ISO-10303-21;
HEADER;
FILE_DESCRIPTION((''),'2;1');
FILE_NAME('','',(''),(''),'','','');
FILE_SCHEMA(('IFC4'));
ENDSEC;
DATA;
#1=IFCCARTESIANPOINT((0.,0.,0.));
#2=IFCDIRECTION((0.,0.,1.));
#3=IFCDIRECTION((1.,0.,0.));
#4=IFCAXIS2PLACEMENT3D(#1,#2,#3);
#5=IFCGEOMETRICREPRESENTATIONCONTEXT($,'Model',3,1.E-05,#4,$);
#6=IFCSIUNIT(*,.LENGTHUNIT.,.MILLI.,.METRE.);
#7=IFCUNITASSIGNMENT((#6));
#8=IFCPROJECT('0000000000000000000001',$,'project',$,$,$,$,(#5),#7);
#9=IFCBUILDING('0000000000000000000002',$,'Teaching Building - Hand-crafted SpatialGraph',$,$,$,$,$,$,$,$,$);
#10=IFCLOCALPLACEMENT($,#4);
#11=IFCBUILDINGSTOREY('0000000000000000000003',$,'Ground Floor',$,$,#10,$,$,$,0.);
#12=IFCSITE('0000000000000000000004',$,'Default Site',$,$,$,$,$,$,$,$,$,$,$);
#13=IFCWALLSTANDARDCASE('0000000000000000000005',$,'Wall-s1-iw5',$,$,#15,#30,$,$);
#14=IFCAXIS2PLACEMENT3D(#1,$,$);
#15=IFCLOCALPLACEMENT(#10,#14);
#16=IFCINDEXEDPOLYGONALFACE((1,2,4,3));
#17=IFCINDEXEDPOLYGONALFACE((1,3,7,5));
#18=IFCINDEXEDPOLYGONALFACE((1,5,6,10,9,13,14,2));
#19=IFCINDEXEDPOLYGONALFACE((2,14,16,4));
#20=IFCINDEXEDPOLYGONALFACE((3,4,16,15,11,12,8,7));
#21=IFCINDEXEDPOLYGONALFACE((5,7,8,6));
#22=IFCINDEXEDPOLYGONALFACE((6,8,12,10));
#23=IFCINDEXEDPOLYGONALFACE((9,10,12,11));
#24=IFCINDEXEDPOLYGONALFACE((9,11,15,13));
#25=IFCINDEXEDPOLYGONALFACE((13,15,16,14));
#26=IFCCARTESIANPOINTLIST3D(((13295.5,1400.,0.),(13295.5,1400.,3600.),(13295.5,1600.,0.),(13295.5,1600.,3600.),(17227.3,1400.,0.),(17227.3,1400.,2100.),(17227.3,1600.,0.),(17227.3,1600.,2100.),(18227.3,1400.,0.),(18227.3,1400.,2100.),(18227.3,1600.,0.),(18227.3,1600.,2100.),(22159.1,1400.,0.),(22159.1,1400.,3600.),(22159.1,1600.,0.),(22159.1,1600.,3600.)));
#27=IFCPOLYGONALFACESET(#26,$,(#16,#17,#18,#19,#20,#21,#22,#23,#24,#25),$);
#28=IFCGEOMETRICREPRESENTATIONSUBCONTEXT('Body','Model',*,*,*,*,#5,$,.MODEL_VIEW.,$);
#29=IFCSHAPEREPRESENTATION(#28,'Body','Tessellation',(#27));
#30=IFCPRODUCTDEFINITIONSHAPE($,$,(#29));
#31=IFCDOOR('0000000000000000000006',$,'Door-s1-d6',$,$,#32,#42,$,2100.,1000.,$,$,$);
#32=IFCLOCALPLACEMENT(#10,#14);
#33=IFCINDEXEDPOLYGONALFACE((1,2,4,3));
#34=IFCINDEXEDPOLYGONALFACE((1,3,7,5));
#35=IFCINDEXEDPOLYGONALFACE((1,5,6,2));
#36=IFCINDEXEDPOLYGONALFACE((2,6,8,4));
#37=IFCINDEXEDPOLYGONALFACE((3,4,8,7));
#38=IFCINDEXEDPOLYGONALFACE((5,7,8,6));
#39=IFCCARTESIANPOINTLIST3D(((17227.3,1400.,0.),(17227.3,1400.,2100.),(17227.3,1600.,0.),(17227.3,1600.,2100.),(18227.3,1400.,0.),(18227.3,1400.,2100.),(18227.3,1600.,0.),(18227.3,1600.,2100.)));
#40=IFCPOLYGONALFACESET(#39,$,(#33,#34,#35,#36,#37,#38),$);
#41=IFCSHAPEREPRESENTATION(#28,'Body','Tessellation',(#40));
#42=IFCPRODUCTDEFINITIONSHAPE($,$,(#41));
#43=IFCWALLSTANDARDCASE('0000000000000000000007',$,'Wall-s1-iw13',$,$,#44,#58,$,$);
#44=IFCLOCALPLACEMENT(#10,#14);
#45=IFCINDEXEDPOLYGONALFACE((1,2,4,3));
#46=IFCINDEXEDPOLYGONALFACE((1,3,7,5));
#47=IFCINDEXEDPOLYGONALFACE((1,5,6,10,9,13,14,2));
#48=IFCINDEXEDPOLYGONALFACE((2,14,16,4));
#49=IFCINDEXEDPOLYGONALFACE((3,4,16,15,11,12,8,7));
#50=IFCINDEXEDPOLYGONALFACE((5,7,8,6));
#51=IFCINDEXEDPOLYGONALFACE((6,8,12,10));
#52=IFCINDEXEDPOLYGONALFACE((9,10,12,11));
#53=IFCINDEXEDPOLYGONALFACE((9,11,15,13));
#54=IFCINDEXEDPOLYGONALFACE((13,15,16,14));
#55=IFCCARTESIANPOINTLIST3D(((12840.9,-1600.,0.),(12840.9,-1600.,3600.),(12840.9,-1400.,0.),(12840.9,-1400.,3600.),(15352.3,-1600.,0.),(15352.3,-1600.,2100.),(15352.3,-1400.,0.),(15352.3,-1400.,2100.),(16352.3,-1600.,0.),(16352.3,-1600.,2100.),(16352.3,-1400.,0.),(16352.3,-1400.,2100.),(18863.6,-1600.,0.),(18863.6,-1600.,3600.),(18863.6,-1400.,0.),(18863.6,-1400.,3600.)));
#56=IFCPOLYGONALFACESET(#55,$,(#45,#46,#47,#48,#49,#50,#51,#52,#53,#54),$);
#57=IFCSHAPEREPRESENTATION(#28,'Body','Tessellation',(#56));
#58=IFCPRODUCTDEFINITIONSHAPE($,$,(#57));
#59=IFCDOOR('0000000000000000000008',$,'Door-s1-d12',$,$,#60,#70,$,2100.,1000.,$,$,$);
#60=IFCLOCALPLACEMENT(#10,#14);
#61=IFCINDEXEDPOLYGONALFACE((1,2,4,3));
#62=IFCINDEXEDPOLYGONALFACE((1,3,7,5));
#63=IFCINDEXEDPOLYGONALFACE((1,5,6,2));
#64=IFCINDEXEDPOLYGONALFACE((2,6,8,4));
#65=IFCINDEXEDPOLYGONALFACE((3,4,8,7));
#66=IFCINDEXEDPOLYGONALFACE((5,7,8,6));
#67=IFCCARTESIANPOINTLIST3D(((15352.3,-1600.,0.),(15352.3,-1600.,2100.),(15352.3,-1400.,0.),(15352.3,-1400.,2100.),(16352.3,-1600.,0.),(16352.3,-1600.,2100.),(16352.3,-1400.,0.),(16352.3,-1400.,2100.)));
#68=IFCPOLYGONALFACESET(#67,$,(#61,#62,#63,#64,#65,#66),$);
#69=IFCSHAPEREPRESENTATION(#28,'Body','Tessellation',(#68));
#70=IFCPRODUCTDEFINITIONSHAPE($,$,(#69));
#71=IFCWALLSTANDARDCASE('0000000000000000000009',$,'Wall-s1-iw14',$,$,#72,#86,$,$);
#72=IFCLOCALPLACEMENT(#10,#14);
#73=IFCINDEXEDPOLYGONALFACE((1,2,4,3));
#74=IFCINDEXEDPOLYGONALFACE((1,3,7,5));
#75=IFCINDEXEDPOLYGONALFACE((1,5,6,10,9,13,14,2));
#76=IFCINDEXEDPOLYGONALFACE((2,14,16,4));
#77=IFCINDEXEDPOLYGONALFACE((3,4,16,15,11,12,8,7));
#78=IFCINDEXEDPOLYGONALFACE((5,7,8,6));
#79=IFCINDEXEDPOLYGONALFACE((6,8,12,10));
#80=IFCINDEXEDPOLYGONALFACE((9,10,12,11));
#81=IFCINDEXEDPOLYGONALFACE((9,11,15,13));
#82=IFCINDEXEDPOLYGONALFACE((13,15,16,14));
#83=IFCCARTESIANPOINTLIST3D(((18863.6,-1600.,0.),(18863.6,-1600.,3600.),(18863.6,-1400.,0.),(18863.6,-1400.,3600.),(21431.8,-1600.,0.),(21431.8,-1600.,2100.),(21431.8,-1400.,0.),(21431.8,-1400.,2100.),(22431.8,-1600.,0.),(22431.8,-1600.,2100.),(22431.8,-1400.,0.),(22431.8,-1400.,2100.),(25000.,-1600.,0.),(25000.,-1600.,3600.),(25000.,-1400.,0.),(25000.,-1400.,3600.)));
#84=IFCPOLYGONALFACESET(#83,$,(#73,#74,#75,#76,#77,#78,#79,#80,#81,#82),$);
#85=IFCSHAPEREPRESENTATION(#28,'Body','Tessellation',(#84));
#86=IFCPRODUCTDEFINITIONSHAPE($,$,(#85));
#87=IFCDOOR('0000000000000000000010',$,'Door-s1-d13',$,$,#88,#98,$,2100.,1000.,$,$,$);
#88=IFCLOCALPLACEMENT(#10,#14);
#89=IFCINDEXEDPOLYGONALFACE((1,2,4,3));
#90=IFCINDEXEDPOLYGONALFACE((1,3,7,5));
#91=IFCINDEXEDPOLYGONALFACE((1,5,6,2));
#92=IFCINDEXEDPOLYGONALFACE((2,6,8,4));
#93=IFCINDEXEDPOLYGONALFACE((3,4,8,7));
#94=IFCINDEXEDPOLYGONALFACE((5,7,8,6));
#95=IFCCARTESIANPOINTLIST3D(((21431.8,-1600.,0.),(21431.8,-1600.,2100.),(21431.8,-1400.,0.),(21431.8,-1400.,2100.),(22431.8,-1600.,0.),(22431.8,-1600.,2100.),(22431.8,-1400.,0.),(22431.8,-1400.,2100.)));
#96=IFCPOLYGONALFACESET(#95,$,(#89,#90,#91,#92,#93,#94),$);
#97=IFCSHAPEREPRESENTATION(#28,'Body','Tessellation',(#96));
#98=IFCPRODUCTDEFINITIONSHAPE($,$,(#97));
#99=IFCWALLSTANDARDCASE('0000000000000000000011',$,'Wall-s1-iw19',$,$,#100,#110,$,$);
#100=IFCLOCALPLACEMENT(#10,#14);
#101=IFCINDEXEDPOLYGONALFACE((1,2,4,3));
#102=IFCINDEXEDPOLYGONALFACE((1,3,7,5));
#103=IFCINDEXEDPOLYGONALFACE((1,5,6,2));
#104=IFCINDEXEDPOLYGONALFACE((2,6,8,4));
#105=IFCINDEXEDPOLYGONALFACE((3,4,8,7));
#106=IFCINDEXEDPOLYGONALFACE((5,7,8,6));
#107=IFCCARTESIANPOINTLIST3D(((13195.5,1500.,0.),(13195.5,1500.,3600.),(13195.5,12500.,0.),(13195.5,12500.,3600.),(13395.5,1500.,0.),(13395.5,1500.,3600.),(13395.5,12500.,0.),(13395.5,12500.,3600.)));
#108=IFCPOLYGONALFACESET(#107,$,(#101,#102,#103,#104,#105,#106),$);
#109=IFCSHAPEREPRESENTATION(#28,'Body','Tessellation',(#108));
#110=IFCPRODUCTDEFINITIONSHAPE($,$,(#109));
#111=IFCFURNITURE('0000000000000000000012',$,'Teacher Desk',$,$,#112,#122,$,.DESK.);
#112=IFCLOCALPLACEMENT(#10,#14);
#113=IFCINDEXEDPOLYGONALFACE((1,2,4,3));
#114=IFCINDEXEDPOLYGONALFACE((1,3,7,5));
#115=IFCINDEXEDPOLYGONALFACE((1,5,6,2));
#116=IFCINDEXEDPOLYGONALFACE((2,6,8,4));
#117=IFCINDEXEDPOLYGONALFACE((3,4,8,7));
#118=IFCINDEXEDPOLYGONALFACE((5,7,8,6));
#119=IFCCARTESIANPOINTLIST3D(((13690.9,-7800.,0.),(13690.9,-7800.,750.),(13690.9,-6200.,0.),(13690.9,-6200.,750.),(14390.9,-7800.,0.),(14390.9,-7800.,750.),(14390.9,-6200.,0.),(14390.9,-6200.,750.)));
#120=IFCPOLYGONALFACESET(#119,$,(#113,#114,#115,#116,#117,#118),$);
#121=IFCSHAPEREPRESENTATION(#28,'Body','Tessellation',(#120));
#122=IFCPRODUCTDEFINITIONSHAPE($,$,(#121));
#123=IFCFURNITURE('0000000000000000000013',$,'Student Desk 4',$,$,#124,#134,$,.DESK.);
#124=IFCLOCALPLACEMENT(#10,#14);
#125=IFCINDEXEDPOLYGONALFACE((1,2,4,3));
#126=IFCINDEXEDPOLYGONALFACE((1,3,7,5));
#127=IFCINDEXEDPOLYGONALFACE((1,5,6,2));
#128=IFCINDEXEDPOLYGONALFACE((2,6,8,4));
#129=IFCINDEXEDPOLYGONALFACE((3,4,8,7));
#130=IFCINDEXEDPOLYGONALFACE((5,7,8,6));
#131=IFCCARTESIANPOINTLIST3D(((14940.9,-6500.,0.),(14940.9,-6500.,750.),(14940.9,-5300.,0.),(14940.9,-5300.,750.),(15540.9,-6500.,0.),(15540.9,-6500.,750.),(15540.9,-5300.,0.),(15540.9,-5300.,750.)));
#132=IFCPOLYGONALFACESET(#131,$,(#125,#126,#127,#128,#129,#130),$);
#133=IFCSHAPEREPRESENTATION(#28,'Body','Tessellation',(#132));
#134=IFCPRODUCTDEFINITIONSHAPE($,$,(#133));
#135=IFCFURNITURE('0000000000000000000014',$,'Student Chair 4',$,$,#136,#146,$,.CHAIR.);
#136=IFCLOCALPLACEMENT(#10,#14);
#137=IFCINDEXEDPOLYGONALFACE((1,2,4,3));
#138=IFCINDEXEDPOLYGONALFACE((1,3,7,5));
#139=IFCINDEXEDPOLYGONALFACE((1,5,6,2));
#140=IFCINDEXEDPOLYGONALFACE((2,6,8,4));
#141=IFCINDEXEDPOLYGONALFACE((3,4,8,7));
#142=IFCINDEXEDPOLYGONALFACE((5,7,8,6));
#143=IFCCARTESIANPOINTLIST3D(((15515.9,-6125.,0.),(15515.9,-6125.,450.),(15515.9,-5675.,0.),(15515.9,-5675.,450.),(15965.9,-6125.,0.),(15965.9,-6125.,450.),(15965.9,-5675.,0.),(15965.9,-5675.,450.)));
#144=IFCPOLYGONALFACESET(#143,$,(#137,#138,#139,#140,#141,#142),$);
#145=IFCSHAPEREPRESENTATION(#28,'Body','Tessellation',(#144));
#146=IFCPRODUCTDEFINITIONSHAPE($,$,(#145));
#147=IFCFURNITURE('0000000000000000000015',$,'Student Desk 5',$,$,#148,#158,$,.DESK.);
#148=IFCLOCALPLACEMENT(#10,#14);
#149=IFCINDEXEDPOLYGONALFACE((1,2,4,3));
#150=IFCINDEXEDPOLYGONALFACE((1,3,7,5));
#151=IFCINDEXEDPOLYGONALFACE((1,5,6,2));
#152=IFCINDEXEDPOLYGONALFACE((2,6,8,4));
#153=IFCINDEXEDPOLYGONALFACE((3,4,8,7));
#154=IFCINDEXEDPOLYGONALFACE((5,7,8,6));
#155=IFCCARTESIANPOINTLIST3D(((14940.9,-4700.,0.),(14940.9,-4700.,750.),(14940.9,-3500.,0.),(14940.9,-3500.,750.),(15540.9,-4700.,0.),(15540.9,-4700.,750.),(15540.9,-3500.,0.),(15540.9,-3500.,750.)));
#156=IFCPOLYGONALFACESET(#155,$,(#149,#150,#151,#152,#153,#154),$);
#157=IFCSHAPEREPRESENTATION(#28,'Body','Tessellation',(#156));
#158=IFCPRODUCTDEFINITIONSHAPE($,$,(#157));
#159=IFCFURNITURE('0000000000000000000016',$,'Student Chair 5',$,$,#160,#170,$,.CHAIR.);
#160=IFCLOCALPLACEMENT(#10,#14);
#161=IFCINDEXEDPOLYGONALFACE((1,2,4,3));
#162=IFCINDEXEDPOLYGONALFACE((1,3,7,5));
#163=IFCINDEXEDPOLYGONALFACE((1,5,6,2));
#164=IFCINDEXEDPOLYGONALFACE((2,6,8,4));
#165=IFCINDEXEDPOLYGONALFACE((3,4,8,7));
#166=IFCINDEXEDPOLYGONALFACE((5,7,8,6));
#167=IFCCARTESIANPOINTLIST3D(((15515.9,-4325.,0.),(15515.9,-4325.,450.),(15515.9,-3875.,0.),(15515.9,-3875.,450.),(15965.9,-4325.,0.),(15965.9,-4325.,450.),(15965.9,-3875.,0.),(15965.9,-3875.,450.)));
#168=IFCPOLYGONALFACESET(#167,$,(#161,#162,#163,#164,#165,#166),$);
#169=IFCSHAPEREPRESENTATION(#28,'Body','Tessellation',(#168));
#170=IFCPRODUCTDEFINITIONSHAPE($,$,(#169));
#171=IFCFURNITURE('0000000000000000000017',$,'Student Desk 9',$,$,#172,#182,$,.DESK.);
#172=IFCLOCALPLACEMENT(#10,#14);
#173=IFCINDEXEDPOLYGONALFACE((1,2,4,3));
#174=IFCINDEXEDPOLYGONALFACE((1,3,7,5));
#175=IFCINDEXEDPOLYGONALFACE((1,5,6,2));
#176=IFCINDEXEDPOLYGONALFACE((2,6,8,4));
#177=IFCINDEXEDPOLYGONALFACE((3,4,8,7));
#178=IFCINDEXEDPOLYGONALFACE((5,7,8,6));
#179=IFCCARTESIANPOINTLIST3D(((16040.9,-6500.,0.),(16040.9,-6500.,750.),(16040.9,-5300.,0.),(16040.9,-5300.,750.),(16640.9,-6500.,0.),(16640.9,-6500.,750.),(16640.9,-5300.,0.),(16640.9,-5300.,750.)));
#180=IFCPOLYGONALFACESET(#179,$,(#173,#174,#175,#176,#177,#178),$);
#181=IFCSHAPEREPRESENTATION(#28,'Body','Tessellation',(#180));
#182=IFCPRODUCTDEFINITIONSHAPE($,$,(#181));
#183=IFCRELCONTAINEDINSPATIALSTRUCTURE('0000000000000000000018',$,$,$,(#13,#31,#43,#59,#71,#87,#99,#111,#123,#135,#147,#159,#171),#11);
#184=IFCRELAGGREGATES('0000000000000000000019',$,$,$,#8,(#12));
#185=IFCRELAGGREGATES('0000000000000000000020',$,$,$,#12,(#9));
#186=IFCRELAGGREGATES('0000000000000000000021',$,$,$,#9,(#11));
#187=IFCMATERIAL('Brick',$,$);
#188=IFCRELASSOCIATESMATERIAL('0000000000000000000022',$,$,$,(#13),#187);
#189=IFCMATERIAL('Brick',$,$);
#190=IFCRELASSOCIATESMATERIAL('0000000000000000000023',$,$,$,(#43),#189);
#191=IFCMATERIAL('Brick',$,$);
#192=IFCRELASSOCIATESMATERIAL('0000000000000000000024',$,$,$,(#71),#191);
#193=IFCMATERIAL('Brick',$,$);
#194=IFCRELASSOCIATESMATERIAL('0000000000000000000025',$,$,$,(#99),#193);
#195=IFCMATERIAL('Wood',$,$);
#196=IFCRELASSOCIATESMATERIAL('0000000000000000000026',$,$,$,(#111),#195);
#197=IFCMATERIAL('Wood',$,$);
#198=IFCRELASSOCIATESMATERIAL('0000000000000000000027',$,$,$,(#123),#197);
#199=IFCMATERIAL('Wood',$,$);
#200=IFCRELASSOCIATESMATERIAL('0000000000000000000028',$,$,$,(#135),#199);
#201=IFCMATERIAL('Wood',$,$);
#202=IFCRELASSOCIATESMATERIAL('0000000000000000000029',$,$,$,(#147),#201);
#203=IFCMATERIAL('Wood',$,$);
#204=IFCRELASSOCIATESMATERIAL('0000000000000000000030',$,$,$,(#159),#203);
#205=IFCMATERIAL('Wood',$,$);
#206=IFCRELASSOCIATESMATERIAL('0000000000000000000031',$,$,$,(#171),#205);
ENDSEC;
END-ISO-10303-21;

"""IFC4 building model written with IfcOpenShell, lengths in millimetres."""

from ifc_helpers import new_model, si_unit, frame, frame_2d, origin_with_axes, origin_2d, place, context, subcontext, project, spatial, rectangle, extrude, material, element, fill, save


model = new_model("IFC4")

# Units and contexts
model_context = context("Model", 3, precision=1e-05, world=origin_with_axes())
body_context = subcontext(model_context, "Body", "Model", "MODEL_VIEW")
ifc_project = project(units=[si_unit("LENGTHUNIT", "METRE", prefix="MILLI")], contexts=[model_context])

# Site, building, storey
site = spatial("IfcSite", under=ifc_project, Name="Default Site")
building = spatial("IfcBuilding", under=site, Name="Teaching Building - Hand-crafted SpatialGraph")
storey_placement = place(None, origin_with_axes())
storey = spatial("IfcBuildingStorey", under=building, at=storey_placement, Name="Ground Floor", Elevation=0.0)

# Walls, openings, doors
ifc_material_1 = material(Name="Brick")
wall_1_placement = place(storey_placement, frame((13295.5, 1500.0, 0.0), z_axis=(0.0, 0.0, 1.0), x_axis=(1.0, 0.0, 0.0)))
wall_1 = element("IfcWallStandardCase", 1, at=wall_1_placement, inside=storey, material=ifc_material_1, Name="Wall-s1-iw5", context=body_context, shape_type="SweptSolid", body=[
    extrude(rectangle(XDim=8863.6, YDim=200.0, at=frame_2d((4431.8, 0.0))), origin_with_axes(), (0.0, 0.0, 1.0), 3600.0),
])
opening_1_placement = place(wall_1_placement, frame((3931.8, 0.0, 0.0), z_axis=(0.0, 0.0, 1.0), x_axis=(1.0, 0.0, 0.0)))
opening_1 = element("IfcOpeningElement", 2, at=opening_1_placement, cuts=wall_1, context=body_context, shape_type="SweptSolid", body=[
    extrude(rectangle(XDim=1000.0, YDim=400.0, at=frame_2d((500.0, 0.0))), origin_with_axes(), (0.0, 0.0, 1.0), 2100.0),
])
door_1_placement = place(storey_placement, frame((17227.3, 1500.0, 0.0), z_axis=(0.0, 0.0, 1.0), x_axis=(1.0, 0.0, 0.0)))
door_1 = element("IfcDoor", 3, at=door_1_placement, inside=storey, Name="Door-s1-d6", OverallHeight=2100.0, OverallWidth=1000.0, context=body_context, shape_type="SweptSolid", body=[
    extrude(rectangle(XDim=1000.0, YDim=200.0, at=frame_2d((500.0, 0.0))), origin_with_axes(), (0.0, 0.0, 1.0), 2100.0),
])
fill(opening_1, door_1)
ifc_material_2 = material(Name="Brick")
wall_2_placement = place(storey_placement, frame((12840.9, -1500.0, 0.0), z_axis=(0.0, 0.0, 1.0), x_axis=(1.0, 0.0, 0.0)))
wall_2 = element("IfcWallStandardCase", 4, at=wall_2_placement, inside=storey, material=ifc_material_2, Name="Wall-s1-iw13", context=body_context, shape_type="SweptSolid", body=[
    extrude(rectangle(XDim=6022.7, YDim=200.0, at=frame_2d((3011.4, 0.0))), origin_with_axes(), (0.0, 0.0, 1.0), 3600.0),
])
opening_2_placement = place(wall_2_placement, frame((2511.4, 0.0, 0.0), z_axis=(0.0, 0.0, 1.0), x_axis=(1.0, 0.0, 0.0)))
opening_2 = element("IfcOpeningElement", 5, at=opening_2_placement, cuts=wall_2, context=body_context, shape_type="SweptSolid", body=[
    extrude(rectangle(XDim=1000.0, YDim=400.0, at=frame_2d((500.0, 0.0))), origin_with_axes(), (0.0, 0.0, 1.0), 2100.0),
])
door_2_placement = place(storey_placement, frame((15352.3, -1500.0, 0.0), z_axis=(0.0, 0.0, 1.0), x_axis=(1.0, 0.0, 0.0)))
door_2 = element("IfcDoor", 6, at=door_2_placement, inside=storey, Name="Door-s1-d12", OverallHeight=2100.0, OverallWidth=1000.0, context=body_context, shape_type="SweptSolid", body=[
    extrude(rectangle(XDim=1000.0, YDim=200.0, at=frame_2d((500.0, 0.0))), origin_with_axes(), (0.0, 0.0, 1.0), 2100.0),
])
fill(opening_2, door_2)
ifc_material_3 = material(Name="Brick")
wall_3_placement = place(storey_placement, frame((18863.6, -1500.0, 0.0), z_axis=(0.0, 0.0, 1.0), x_axis=(1.0, 0.0, 0.0)))
wall_3 = element("IfcWallStandardCase", 7, at=wall_3_placement, inside=storey, material=ifc_material_3, Name="Wall-s1-iw14", context=body_context, shape_type="SweptSolid", body=[
    extrude(rectangle(XDim=6136.4, YDim=200.0, at=frame_2d((3068.2, 0.0))), origin_with_axes(), (0.0, 0.0, 1.0), 3600.0),
])
opening_3_placement = place(wall_3_placement, frame((2568.2, 0.0, 0.0), z_axis=(0.0, 0.0, 1.0), x_axis=(1.0, 0.0, 0.0)))
opening_3 = element("IfcOpeningElement", 8, at=opening_3_placement, cuts=wall_3, context=body_context, shape_type="SweptSolid", body=[
    extrude(rectangle(XDim=1000.0, YDim=400.0, at=frame_2d((500.0, 0.0))), origin_with_axes(), (0.0, 0.0, 1.0), 2100.0),
])
door_3_placement = place(storey_placement, frame((21431.8, -1500.0, 0.0), z_axis=(0.0, 0.0, 1.0), x_axis=(1.0, 0.0, 0.0)))
door_3 = element("IfcDoor", 9, at=door_3_placement, inside=storey, Name="Door-s1-d13", OverallHeight=2100.0, OverallWidth=1000.0, context=body_context, shape_type="SweptSolid", body=[
    extrude(rectangle(XDim=1000.0, YDim=200.0, at=frame_2d((500.0, 0.0))), origin_with_axes(), (0.0, 0.0, 1.0), 2100.0),
])
fill(opening_3, door_3)

# Wall
ifc_material_4 = material(Name="Brick")
wall_4_placement = place(storey_placement, frame((13295.5, 1500.0, 0.0), z_axis=(0.0, 0.0, 1.0), x_axis=(0.0, 1.0, 0.0)))
element("IfcWallStandardCase", 10, at=wall_4_placement, inside=storey, material=ifc_material_4, Name="Wall-s1-iw19", context=body_context, shape_type="SweptSolid", body=[
    extrude(rectangle(XDim=11000.0, YDim=200.0, at=frame_2d((5500.0, 0.0))), origin_with_axes(), (0.0, 0.0, 1.0), 3600.0),
])

# Furniture
ifc_material_5 = material(Name="Wood")
furniture_1_placement = place(storey_placement, frame((14040.9, -7000.0, 0.0), z_axis=(0.0, 0.0, 1.0), x_axis=(0.0, 1.0, 0.0)))
element("IfcFurniture", 11, at=furniture_1_placement, inside=storey, material=ifc_material_5, Name="Teacher Desk", PredefinedType="DESK", context=body_context, shape_type="SweptSolid", body=[
    extrude(rectangle(XDim=1600.0, YDim=700.0, at=origin_2d()), origin_with_axes(), (0.0, 0.0, 1.0), 750.0),
])
ifc_material_6 = material(Name="Wood")
furniture_2_placement = place(storey_placement, frame((15240.9, -5900.0, 0.0), z_axis=(0.0, 0.0, 1.0), x_axis=(0.0, 1.0, 0.0)))
element("IfcFurniture", 12, at=furniture_2_placement, inside=storey, material=ifc_material_6, Name="Student Desk 4", PredefinedType="DESK", context=body_context, shape_type="SweptSolid", body=[
    extrude(rectangle(XDim=1200.0, YDim=600.0, at=origin_2d()), origin_with_axes(), (0.0, 0.0, 1.0), 750.0),
])
ifc_material_7 = material(Name="Wood")
furniture_3_placement = place(storey_placement, frame((15740.9, -5900.0, 0.0), z_axis=(0.0, 0.0, 1.0), x_axis=(1.0, 0.0, 0.0)))
element("IfcFurniture", 13, at=furniture_3_placement, inside=storey, material=ifc_material_7, Name="Student Chair 4", PredefinedType="CHAIR", context=body_context, shape_type="SweptSolid", body=[
    extrude(rectangle(XDim=450.0, YDim=450.0, at=origin_2d()), origin_with_axes(), (0.0, 0.0, 1.0), 450.0),
])
ifc_material_8 = material(Name="Wood")
furniture_4_placement = place(storey_placement, frame((15240.9, -4100.0, 0.0), z_axis=(0.0, 0.0, 1.0), x_axis=(0.0, 1.0, 0.0)))
element("IfcFurniture", 14, at=furniture_4_placement, inside=storey, material=ifc_material_8, Name="Student Desk 5", PredefinedType="DESK", context=body_context, shape_type="SweptSolid", body=[
    extrude(rectangle(XDim=1200.0, YDim=600.0, at=origin_2d()), origin_with_axes(), (0.0, 0.0, 1.0), 750.0),
])
ifc_material_9 = material(Name="Wood")
furniture_5_placement = place(storey_placement, frame((15740.9, -4100.0, 0.0), z_axis=(0.0, 0.0, 1.0), x_axis=(1.0, 0.0, 0.0)))
element("IfcFurniture", 15, at=furniture_5_placement, inside=storey, material=ifc_material_9, Name="Student Chair 5", PredefinedType="CHAIR", context=body_context, shape_type="SweptSolid", body=[
    extrude(rectangle(XDim=450.0, YDim=450.0, at=origin_2d()), origin_with_axes(), (0.0, 0.0, 1.0), 450.0),
])
ifc_material_10 = material(Name="Wood")
furniture_6_placement = place(storey_placement, frame((16340.9, -5900.0, 0.0), z_axis=(0.0, 0.0, 1.0), x_axis=(0.0, 1.0, 0.0)))
element("IfcFurniture", 16, at=furniture_6_placement, inside=storey, material=ifc_material_10, Name="Student Desk 9", PredefinedType="DESK", context=body_context, shape_type="SweptSolid", body=[
    extrude(rectangle(XDim=1200.0, YDim=600.0, at=origin_2d()), origin_with_axes(), (0.0, 0.0, 1.0), 750.0),
])

save(model, "model.ifc")
